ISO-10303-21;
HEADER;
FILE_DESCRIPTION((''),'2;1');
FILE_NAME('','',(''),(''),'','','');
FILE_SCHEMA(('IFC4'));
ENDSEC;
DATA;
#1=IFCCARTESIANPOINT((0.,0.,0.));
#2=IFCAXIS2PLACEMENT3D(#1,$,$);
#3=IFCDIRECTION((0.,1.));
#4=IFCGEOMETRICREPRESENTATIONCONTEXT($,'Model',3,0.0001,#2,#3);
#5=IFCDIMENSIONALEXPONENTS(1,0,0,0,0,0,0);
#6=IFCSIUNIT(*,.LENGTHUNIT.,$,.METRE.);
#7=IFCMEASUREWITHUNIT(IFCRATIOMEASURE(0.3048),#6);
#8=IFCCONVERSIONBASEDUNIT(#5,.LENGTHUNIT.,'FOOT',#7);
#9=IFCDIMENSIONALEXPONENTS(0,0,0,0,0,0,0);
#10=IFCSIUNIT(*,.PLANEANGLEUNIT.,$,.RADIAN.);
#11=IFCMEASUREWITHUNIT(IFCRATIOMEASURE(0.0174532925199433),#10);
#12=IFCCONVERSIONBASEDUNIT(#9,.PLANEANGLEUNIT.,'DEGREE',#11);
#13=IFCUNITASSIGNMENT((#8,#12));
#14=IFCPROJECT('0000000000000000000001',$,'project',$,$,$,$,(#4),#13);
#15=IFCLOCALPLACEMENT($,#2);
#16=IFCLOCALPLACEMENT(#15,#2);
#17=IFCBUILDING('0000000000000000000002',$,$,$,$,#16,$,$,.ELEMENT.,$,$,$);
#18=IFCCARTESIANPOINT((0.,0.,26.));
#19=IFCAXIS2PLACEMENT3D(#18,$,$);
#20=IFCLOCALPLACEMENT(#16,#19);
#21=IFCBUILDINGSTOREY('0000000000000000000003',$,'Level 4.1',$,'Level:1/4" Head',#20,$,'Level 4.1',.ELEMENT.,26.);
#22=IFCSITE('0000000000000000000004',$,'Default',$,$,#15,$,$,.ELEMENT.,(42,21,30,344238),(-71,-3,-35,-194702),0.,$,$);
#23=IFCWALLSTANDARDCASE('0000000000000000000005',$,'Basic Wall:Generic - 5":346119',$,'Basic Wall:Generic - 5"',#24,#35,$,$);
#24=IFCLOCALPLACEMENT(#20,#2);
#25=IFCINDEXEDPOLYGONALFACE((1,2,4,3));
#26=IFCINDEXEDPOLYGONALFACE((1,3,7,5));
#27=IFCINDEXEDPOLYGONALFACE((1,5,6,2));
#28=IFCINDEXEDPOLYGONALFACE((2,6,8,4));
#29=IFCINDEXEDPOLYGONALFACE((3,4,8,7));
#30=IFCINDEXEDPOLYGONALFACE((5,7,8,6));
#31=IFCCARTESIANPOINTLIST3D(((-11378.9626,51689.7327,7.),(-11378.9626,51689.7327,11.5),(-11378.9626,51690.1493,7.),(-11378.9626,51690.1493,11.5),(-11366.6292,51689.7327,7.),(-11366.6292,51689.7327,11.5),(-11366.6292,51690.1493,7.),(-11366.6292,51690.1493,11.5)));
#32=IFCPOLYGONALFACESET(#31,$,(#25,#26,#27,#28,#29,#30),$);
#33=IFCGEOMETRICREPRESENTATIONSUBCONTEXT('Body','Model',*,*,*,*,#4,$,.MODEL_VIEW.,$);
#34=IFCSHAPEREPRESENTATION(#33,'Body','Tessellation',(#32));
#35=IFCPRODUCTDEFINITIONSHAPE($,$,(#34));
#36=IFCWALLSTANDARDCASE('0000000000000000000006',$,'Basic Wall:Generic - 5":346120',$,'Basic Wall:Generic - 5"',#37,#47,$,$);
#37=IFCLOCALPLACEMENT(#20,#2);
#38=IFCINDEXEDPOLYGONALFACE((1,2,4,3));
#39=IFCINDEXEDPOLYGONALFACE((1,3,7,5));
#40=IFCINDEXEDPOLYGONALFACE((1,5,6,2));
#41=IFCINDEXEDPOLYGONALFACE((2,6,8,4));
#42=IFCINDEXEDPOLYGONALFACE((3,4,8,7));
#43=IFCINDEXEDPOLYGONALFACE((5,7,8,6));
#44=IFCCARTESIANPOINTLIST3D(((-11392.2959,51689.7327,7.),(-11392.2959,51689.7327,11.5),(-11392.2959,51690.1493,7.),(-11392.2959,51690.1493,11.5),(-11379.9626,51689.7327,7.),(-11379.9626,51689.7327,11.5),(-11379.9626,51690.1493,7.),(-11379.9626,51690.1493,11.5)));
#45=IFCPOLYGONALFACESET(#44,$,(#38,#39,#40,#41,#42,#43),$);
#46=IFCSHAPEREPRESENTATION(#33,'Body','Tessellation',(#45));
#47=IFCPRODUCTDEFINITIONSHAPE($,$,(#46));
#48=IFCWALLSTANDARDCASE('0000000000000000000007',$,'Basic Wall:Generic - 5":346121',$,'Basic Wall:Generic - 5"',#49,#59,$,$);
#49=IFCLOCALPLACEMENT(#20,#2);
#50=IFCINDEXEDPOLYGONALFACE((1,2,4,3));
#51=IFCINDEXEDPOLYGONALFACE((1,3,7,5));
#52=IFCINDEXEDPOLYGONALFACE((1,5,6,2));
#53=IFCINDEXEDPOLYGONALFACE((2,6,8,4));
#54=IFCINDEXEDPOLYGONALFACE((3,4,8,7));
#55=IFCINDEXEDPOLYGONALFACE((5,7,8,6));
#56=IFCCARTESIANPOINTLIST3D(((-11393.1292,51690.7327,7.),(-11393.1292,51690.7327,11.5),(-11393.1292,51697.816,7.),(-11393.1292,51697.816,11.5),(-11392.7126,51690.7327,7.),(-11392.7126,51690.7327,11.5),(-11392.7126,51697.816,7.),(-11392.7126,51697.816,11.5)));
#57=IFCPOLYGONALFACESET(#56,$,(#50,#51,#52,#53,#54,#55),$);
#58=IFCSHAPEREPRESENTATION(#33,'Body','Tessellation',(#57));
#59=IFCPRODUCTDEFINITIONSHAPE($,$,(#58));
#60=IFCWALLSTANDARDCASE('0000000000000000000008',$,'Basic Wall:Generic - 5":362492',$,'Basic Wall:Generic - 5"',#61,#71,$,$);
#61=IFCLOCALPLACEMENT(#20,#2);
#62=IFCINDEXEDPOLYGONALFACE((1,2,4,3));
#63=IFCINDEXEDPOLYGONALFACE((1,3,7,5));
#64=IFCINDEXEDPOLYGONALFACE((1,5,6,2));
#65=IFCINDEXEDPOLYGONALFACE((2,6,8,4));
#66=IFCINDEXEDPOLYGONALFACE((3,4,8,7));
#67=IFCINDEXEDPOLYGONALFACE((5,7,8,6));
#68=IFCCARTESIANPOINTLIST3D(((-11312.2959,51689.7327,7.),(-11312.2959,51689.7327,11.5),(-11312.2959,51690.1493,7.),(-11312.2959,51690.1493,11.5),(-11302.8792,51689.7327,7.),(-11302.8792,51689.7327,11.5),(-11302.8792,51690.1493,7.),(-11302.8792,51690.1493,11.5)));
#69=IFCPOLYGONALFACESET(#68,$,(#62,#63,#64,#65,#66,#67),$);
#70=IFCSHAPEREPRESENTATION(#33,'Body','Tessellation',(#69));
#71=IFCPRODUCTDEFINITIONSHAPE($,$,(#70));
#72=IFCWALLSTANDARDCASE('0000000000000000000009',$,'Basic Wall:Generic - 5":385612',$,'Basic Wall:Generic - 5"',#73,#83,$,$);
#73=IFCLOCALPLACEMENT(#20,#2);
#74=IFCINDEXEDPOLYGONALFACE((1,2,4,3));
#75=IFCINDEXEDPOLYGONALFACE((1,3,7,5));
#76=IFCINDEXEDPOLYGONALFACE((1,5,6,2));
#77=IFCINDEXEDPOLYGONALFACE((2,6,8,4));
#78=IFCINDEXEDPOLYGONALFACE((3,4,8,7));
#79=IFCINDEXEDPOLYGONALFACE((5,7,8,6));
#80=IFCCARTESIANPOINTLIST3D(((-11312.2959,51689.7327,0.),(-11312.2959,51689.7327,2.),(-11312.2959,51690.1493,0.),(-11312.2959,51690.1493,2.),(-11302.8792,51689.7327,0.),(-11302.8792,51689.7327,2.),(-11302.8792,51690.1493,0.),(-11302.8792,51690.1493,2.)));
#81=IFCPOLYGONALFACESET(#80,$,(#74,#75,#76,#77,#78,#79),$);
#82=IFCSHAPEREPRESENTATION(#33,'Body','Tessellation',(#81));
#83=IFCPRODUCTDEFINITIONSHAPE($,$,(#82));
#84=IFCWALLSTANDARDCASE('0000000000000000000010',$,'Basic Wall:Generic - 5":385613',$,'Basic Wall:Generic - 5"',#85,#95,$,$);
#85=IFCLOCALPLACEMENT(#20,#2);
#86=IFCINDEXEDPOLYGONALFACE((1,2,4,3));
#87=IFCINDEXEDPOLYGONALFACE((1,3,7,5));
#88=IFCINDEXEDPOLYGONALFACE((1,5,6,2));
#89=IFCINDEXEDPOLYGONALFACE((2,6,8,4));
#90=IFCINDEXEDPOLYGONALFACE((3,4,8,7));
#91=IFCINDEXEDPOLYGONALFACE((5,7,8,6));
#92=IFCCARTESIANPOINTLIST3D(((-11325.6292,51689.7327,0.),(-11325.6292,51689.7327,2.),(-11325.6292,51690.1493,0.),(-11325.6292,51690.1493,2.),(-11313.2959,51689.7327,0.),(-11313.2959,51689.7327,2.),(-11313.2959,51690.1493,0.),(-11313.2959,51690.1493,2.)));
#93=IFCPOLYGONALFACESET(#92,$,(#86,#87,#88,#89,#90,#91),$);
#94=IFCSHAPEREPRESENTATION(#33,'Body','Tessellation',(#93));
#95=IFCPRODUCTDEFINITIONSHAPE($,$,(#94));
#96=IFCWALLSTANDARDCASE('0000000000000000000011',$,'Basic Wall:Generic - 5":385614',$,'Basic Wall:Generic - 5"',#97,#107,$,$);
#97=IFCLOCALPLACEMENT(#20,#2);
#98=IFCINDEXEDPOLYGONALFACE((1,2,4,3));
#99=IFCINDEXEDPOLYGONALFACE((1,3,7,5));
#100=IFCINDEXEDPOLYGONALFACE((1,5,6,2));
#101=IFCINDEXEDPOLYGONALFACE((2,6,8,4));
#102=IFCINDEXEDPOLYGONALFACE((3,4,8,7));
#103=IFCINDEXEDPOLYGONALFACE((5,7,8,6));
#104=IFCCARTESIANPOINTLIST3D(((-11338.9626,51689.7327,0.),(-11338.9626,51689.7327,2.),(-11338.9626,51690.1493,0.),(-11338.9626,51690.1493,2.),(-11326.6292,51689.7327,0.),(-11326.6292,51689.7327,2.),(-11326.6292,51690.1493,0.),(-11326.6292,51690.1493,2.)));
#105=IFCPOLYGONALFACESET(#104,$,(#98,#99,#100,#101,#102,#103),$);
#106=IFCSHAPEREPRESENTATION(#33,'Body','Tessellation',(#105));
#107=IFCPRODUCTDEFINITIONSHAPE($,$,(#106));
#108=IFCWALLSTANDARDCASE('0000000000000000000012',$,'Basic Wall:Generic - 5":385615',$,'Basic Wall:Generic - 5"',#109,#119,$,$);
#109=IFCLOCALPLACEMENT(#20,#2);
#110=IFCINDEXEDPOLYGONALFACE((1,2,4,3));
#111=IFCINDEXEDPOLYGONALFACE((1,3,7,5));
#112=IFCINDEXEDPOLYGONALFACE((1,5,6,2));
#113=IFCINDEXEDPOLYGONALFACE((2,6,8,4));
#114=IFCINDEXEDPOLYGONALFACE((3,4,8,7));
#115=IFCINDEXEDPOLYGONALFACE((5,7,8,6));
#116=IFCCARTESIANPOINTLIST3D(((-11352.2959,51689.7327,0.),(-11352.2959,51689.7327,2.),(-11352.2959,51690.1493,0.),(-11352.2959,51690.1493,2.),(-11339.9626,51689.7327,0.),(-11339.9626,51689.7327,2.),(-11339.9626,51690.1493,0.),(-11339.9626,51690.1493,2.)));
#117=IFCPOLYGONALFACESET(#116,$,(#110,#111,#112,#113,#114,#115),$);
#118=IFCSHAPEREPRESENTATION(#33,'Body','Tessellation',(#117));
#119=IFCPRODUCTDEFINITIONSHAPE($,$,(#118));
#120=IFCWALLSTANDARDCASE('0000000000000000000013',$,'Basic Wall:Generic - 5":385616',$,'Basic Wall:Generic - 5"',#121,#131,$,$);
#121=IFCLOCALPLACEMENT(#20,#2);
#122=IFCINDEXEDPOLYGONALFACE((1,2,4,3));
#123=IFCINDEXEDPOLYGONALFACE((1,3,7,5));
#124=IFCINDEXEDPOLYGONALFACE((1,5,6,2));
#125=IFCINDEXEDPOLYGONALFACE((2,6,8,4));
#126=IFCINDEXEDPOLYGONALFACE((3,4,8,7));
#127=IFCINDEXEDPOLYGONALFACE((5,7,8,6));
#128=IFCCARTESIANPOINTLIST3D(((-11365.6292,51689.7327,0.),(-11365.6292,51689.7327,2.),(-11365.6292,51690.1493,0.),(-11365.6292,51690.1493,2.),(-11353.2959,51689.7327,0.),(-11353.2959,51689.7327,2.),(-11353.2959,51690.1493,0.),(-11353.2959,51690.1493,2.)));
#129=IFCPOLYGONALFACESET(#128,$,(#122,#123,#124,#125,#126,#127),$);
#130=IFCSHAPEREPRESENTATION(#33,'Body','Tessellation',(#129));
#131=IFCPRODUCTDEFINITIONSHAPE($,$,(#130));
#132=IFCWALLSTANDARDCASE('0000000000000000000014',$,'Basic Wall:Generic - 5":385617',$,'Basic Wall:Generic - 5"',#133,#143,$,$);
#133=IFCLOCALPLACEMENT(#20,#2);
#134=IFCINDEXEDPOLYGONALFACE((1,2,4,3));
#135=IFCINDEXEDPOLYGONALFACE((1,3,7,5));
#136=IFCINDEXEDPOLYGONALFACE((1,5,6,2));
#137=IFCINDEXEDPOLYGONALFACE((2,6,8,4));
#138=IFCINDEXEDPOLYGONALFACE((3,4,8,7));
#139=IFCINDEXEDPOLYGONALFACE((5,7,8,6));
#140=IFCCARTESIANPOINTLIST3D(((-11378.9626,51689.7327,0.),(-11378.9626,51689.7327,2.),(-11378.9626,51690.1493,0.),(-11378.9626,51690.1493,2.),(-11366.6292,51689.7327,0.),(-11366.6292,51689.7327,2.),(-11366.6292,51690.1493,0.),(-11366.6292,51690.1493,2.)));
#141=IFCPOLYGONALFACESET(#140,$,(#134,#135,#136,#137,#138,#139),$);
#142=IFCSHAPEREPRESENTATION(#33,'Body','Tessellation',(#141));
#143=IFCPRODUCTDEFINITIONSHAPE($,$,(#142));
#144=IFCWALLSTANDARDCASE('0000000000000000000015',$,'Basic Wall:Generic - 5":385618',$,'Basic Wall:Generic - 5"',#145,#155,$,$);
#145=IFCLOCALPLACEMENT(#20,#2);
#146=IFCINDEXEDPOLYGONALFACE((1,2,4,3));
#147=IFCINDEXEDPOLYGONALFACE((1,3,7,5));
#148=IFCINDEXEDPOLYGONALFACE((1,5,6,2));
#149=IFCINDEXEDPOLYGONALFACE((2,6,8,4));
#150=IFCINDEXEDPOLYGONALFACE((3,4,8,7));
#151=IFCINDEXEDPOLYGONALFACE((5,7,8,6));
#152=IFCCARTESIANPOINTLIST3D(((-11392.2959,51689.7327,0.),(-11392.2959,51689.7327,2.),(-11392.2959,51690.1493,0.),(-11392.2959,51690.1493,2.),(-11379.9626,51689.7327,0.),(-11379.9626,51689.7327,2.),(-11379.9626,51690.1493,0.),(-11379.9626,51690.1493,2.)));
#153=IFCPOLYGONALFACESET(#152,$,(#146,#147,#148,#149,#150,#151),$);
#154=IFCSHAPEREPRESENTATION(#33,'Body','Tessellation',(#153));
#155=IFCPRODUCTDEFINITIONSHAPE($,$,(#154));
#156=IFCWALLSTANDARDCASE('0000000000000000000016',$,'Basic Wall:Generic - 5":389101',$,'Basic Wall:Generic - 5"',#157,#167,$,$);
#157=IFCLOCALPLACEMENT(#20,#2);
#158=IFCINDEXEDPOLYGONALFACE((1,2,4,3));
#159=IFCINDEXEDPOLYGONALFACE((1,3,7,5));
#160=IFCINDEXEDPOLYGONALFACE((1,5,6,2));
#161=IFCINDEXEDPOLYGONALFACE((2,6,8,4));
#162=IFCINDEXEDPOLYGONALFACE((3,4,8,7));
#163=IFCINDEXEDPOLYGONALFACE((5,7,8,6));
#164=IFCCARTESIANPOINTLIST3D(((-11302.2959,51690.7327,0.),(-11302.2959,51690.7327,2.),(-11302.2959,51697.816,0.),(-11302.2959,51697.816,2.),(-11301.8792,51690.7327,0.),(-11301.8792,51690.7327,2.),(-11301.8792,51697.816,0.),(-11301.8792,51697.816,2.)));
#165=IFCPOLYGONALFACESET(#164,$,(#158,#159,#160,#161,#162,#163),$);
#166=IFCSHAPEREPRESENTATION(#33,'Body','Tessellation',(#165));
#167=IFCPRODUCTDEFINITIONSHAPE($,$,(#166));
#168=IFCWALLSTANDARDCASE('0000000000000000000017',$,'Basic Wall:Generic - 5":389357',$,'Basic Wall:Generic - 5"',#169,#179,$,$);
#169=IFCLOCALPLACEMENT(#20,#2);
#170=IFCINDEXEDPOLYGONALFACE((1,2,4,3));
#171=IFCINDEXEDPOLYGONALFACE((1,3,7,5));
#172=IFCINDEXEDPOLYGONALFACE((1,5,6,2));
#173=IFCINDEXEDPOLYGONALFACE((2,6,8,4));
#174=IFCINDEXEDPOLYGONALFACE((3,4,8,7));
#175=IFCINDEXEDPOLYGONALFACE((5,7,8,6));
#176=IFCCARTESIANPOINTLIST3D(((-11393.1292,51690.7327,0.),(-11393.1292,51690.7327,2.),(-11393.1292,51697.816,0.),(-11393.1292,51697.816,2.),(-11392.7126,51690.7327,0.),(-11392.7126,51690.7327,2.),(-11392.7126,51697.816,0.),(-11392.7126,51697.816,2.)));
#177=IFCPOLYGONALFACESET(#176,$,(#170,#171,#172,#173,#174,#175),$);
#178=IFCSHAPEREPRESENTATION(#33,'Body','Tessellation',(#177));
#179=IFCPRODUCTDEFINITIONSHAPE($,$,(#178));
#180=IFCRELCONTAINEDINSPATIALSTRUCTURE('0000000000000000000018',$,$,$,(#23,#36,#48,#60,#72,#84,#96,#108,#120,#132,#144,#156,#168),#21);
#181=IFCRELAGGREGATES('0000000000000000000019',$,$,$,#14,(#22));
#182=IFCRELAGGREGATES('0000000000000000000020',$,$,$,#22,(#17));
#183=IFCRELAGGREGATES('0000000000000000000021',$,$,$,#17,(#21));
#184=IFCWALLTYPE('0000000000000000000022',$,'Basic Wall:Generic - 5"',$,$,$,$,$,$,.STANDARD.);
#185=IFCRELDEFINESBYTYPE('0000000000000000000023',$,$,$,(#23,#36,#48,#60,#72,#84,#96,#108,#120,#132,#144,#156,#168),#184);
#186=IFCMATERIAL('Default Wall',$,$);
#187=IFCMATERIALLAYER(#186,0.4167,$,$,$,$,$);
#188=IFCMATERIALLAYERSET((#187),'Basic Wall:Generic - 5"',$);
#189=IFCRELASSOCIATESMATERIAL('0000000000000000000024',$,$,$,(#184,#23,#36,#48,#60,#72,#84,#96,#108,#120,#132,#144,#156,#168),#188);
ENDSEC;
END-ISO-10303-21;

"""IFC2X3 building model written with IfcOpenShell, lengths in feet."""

from ifc_helpers import new_model, entity, si_unit, converted_unit, direction, frame, frame_2d, origin, place, context, subcontext, project, spatial, rectangle, extrude, material, layer, layer_set, layer_usage, type_object, element, save


model = new_model("IFC2X3")

# Units and contexts
model_context = context("Model", 3, precision=0.0001, world=origin(), true_north=direction((0.0, 1.0)))
body_context = subcontext(model_context, "Body", "Model", "MODEL_VIEW")
ifc_project = project(units=[converted_unit("LENGTHUNIT", "FOOT", entity("IfcRatioMeasure", 0.3048), si_unit("LENGTHUNIT", "METRE"), dimensions=[1, 0, 0, 0, 0, 0, 0]), converted_unit("PLANEANGLEUNIT", "DEGREE", entity("IfcRatioMeasure", 0.0174532925199433), si_unit("PLANEANGLEUNIT", "RADIAN"), dimensions=[0, 0, 0, 0, 0, 0, 0])], contexts=[model_context])

# Site, building, storey
site_placement = place(None, origin())
site = spatial("IfcSite", under=ifc_project, at=site_placement, Name="Default", CompositionType="ELEMENT", RefLatitude=(42, 21, 30, 344238), RefLongitude=(-71, -3, -35, -194702), RefElevation=0.0)
building_placement = place(site_placement, origin())
building = spatial("IfcBuilding", under=site, at=building_placement, CompositionType="ELEMENT")
storey_placement = place(building_placement, frame((0.0, 0.0, 26.0)))
storey = spatial("IfcBuildingStorey", under=building, at=storey_placement, Name="Level 4.1", ObjectType="Level:1/4\" Head", LongName="Level 4.1", CompositionType="ELEMENT", Elevation=26.0)

# Shared definitions
ifc_material_1 = material(Name="Default Wall")
ifc_layer = layer(ifc_material_1, 0.4167)
ifc_layer_set = layer_set([ifc_layer], Name="Basic Wall:Generic - 5\"")
wall_type = type_object("IfcWallType", Name="Basic Wall:Generic - 5\"", PredefinedType="STANDARD", material=ifc_layer_set)

# Walls
ifc_layer_usage_1 = layer_usage(ifc_layer_set, "AXIS2", "NEGATIVE", 0.2083)
wall_1_placement = place(storey_placement, frame((-11366.6292, 51689.941, 7.0), z_axis=(0.0, 0.0, 1.0), x_axis=(-1.0, 0.0, 0.0)))
element("IfcWallStandardCase", 1, at=wall_1_placement, inside=storey, type_object=wall_type, material=ifc_layer_usage_1, Name="Basic Wall:Generic - 5\":346119", ObjectType="Basic Wall:Generic - 5\"", context=body_context, shape_type="SweptSolid", body=[
    extrude(rectangle(XDim=12.3333, YDim=0.4167, at=frame_2d((6.1667, 0.0), x_axis=(-1.0, 0.0))), origin(), (0.0, 0.0, 1.0), 4.5),
])
ifc_layer_usage_2 = layer_usage(ifc_layer_set, "AXIS2", "NEGATIVE", 0.2083)
wall_2_placement = place(storey_placement, frame((-11379.9626, 51689.941, 7.0), z_axis=(0.0, 0.0, 1.0), x_axis=(-1.0, 0.0, 0.0)))
element("IfcWallStandardCase", 2, at=wall_2_placement, inside=storey, type_object=wall_type, material=ifc_layer_usage_2, Name="Basic Wall:Generic - 5\":346120", ObjectType="Basic Wall:Generic - 5\"", context=body_context, shape_type="SweptSolid", body=[
    extrude(rectangle(XDim=12.3333, YDim=0.4167, at=frame_2d((6.1667, 0.0), x_axis=(-1.0, 0.0))), origin(), (0.0, 0.0, 1.0), 4.5),
])
ifc_layer_usage_3 = layer_usage(ifc_layer_set, "AXIS2", "POSITIVE", -0.2083)
wall_3_placement = place(storey_placement, frame((-11392.9209, 51697.816, 7.0), z_axis=(0.0, 0.0, 1.0), x_axis=(0.0, -1.0, 0.0)))
element("IfcWallStandardCase", 3, at=wall_3_placement, inside=storey, type_object=wall_type, material=ifc_layer_usage_3, Name="Basic Wall:Generic - 5\":346121", ObjectType="Basic Wall:Generic - 5\"", context=body_context, shape_type="SweptSolid", body=[
    extrude(rectangle(XDim=7.0833, YDim=0.4167, at=frame_2d((3.5417, 0.0), x_axis=(-1.0, 0.0))), origin(), (0.0, 0.0, 1.0), 4.5),
])
ifc_layer_usage_4 = layer_usage(ifc_layer_set, "AXIS2", "NEGATIVE", 0.2083)
wall_4_placement = place(storey_placement, frame((-11302.8792, 51689.941, 7.0), z_axis=(0.0, 0.0, 1.0), x_axis=(-1.0, 0.0, 0.0)))
element("IfcWallStandardCase", 4, at=wall_4_placement, inside=storey, type_object=wall_type, material=ifc_layer_usage_4, Name="Basic Wall:Generic - 5\":362492", ObjectType="Basic Wall:Generic - 5\"", context=body_context, shape_type="SweptSolid", body=[
    extrude(rectangle(XDim=9.4167, YDim=0.4167, at=frame_2d((4.7083, 0.0), x_axis=(-1.0, 0.0))), origin(), (0.0, 0.0, 1.0), 4.5),
])
ifc_layer_usage_5 = layer_usage(ifc_layer_set, "AXIS2", "NEGATIVE", 0.2083)
wall_5_placement = place(storey_placement, frame((-11302.8792, 51689.941, 0.0), z_axis=(0.0, 0.0, 1.0), x_axis=(-1.0, 0.0, 0.0)))
element("IfcWallStandardCase", 5, at=wall_5_placement, inside=storey, type_object=wall_type, material=ifc_layer_usage_5, Name="Basic Wall:Generic - 5\":385612", ObjectType="Basic Wall:Generic - 5\"", context=body_context, shape_type="SweptSolid", body=[
    extrude(rectangle(XDim=9.4167, YDim=0.4167, at=frame_2d((4.7083, 0.0), x_axis=(-1.0, 0.0))), origin(), (0.0, 0.0, 1.0), 2.0),
])
ifc_layer_usage_6 = layer_usage(ifc_layer_set, "AXIS2", "NEGATIVE", 0.2083)
wall_6_placement = place(storey_placement, frame((-11313.2959, 51689.941, 0.0), z_axis=(0.0, 0.0, 1.0), x_axis=(-1.0, 0.0, 0.0)))
element("IfcWallStandardCase", 6, at=wall_6_placement, inside=storey, type_object=wall_type, material=ifc_layer_usage_6, Name="Basic Wall:Generic - 5\":385613", ObjectType="Basic Wall:Generic - 5\"", context=body_context, shape_type="SweptSolid", body=[
    extrude(rectangle(XDim=12.3333, YDim=0.4167, at=frame_2d((6.1667, 0.0), x_axis=(-1.0, 0.0))), origin(), (0.0, 0.0, 1.0), 2.0),
])
ifc_layer_usage_7 = layer_usage(ifc_layer_set, "AXIS2", "NEGATIVE", 0.2083)
wall_7_placement = place(storey_placement, frame((-11326.6292, 51689.941, 0.0), z_axis=(0.0, 0.0, 1.0), x_axis=(-1.0, 0.0, 0.0)))
element("IfcWallStandardCase", 7, at=wall_7_placement, inside=storey, type_object=wall_type, material=ifc_layer_usage_7, Name="Basic Wall:Generic - 5\":385614", ObjectType="Basic Wall:Generic - 5\"", context=body_context, shape_type="SweptSolid", body=[
    extrude(rectangle(XDim=12.3333, YDim=0.4167, at=frame_2d((6.1667, 0.0), x_axis=(-1.0, 0.0))), origin(), (0.0, 0.0, 1.0), 2.0),
])
ifc_layer_usage_8 = layer_usage(ifc_layer_set, "AXIS2", "NEGATIVE", 0.2083)
wall_8_placement = place(storey_placement, frame((-11339.9626, 51689.941, 0.0), z_axis=(0.0, 0.0, 1.0), x_axis=(-1.0, 0.0, 0.0)))
element("IfcWallStandardCase", 8, at=wall_8_placement, inside=storey, type_object=wall_type, material=ifc_layer_usage_8, Name="Basic Wall:Generic - 5\":385615", ObjectType="Basic Wall:Generic - 5\"", context=body_context, shape_type="SweptSolid", body=[
    extrude(rectangle(XDim=12.3333, YDim=0.4167, at=frame_2d((6.1667, 0.0), x_axis=(-1.0, 0.0))), origin(), (0.0, 0.0, 1.0), 2.0),
])
ifc_layer_usage_9 = layer_usage(ifc_layer_set, "AXIS2", "NEGATIVE", 0.2083)
wall_9_placement = place(storey_placement, frame((-11353.2959, 51689.941, 0.0), z_axis=(0.0, 0.0, 1.0), x_axis=(-1.0, 0.0, 0.0)))
element("IfcWallStandardCase", 9, at=wall_9_placement, inside=storey, type_object=wall_type, material=ifc_layer_usage_9, Name="Basic Wall:Generic - 5\":385616", ObjectType="Basic Wall:Generic - 5\"", context=body_context, shape_type="SweptSolid", body=[
    extrude(rectangle(XDim=12.3333, YDim=0.4167, at=frame_2d((6.1667, 0.0), x_axis=(-1.0, 0.0))), origin(), (0.0, 0.0, 1.0), 2.0),
])
ifc_layer_usage_10 = layer_usage(ifc_layer_set, "AXIS2", "NEGATIVE", 0.2083)
wall_10_placement = place(storey_placement, frame((-11366.6292, 51689.941, 0.0), z_axis=(0.0, 0.0, 1.0), x_axis=(-1.0, 0.0, 0.0)))
element("IfcWallStandardCase", 10, at=wall_10_placement, inside=storey, type_object=wall_type, material=ifc_layer_usage_10, Name="Basic Wall:Generic - 5\":385617", ObjectType="Basic Wall:Generic - 5\"", context=body_context, shape_type="SweptSolid", body=[
    extrude(rectangle(XDim=12.3333, YDim=0.4167, at=frame_2d((6.1667, 0.0), x_axis=(-1.0, 0.0))), origin(), (0.0, 0.0, 1.0), 2.0),
])
ifc_layer_usage_11 = layer_usage(ifc_layer_set, "AXIS2", "NEGATIVE", 0.2083)
wall_11_placement = place(storey_placement, frame((-11379.9626, 51689.941, 0.0), z_axis=(0.0, 0.0, 1.0), x_axis=(-1.0, 0.0, 0.0)))
element("IfcWallStandardCase", 11, at=wall_11_placement, inside=storey, type_object=wall_type, material=ifc_layer_usage_11, Name="Basic Wall:Generic - 5\":385618", ObjectType="Basic Wall:Generic - 5\"", context=body_context, shape_type="SweptSolid", body=[
    extrude(rectangle(XDim=12.3333, YDim=0.4167, at=frame_2d((6.1667, 0.0), x_axis=(-1.0, 0.0))), origin(), (0.0, 0.0, 1.0), 2.0),
])
ifc_layer_usage_12 = layer_usage(ifc_layer_set, "AXIS2", "POSITIVE", -0.2083)
wall_12_placement = place(storey_placement, frame((-11302.0876, 51690.7327, 0.0), z_axis=(0.0, 0.0, 1.0), x_axis=(0.0, 1.0, 0.0)))
element("IfcWallStandardCase", 12, at=wall_12_placement, inside=storey, type_object=wall_type, material=ifc_layer_usage_12, Name="Basic Wall:Generic - 5\":389101", ObjectType="Basic Wall:Generic - 5\"", context=body_context, shape_type="SweptSolid", body=[
    extrude(rectangle(XDim=7.0833, YDim=0.4167, at=frame_2d((3.5417, 0.0), x_axis=(-1.0, 0.0))), origin(), (0.0, 0.0, 1.0), 2.0),
])
ifc_layer_usage_13 = layer_usage(ifc_layer_set, "AXIS2", "NEGATIVE", 0.2083)
wall_13_placement = place(storey_placement, frame((-11392.9209, 51690.7327, 0.0), z_axis=(0.0, 0.0, 1.0), x_axis=(0.0, 1.0, 0.0)))
element("IfcWallStandardCase", 13, at=wall_13_placement, inside=storey, type_object=wall_type, material=ifc_layer_usage_13, Name="Basic Wall:Generic - 5\":389357", ObjectType="Basic Wall:Generic - 5\"", context=body_context, shape_type="SweptSolid", body=[
    extrude(rectangle(XDim=7.0833, YDim=0.4167, at=frame_2d((3.5417, 0.0), x_axis=(-1.0, 0.0))), origin(), (0.0, 0.0, 1.0), 2.0),
])

save(model, "model.ifc")
